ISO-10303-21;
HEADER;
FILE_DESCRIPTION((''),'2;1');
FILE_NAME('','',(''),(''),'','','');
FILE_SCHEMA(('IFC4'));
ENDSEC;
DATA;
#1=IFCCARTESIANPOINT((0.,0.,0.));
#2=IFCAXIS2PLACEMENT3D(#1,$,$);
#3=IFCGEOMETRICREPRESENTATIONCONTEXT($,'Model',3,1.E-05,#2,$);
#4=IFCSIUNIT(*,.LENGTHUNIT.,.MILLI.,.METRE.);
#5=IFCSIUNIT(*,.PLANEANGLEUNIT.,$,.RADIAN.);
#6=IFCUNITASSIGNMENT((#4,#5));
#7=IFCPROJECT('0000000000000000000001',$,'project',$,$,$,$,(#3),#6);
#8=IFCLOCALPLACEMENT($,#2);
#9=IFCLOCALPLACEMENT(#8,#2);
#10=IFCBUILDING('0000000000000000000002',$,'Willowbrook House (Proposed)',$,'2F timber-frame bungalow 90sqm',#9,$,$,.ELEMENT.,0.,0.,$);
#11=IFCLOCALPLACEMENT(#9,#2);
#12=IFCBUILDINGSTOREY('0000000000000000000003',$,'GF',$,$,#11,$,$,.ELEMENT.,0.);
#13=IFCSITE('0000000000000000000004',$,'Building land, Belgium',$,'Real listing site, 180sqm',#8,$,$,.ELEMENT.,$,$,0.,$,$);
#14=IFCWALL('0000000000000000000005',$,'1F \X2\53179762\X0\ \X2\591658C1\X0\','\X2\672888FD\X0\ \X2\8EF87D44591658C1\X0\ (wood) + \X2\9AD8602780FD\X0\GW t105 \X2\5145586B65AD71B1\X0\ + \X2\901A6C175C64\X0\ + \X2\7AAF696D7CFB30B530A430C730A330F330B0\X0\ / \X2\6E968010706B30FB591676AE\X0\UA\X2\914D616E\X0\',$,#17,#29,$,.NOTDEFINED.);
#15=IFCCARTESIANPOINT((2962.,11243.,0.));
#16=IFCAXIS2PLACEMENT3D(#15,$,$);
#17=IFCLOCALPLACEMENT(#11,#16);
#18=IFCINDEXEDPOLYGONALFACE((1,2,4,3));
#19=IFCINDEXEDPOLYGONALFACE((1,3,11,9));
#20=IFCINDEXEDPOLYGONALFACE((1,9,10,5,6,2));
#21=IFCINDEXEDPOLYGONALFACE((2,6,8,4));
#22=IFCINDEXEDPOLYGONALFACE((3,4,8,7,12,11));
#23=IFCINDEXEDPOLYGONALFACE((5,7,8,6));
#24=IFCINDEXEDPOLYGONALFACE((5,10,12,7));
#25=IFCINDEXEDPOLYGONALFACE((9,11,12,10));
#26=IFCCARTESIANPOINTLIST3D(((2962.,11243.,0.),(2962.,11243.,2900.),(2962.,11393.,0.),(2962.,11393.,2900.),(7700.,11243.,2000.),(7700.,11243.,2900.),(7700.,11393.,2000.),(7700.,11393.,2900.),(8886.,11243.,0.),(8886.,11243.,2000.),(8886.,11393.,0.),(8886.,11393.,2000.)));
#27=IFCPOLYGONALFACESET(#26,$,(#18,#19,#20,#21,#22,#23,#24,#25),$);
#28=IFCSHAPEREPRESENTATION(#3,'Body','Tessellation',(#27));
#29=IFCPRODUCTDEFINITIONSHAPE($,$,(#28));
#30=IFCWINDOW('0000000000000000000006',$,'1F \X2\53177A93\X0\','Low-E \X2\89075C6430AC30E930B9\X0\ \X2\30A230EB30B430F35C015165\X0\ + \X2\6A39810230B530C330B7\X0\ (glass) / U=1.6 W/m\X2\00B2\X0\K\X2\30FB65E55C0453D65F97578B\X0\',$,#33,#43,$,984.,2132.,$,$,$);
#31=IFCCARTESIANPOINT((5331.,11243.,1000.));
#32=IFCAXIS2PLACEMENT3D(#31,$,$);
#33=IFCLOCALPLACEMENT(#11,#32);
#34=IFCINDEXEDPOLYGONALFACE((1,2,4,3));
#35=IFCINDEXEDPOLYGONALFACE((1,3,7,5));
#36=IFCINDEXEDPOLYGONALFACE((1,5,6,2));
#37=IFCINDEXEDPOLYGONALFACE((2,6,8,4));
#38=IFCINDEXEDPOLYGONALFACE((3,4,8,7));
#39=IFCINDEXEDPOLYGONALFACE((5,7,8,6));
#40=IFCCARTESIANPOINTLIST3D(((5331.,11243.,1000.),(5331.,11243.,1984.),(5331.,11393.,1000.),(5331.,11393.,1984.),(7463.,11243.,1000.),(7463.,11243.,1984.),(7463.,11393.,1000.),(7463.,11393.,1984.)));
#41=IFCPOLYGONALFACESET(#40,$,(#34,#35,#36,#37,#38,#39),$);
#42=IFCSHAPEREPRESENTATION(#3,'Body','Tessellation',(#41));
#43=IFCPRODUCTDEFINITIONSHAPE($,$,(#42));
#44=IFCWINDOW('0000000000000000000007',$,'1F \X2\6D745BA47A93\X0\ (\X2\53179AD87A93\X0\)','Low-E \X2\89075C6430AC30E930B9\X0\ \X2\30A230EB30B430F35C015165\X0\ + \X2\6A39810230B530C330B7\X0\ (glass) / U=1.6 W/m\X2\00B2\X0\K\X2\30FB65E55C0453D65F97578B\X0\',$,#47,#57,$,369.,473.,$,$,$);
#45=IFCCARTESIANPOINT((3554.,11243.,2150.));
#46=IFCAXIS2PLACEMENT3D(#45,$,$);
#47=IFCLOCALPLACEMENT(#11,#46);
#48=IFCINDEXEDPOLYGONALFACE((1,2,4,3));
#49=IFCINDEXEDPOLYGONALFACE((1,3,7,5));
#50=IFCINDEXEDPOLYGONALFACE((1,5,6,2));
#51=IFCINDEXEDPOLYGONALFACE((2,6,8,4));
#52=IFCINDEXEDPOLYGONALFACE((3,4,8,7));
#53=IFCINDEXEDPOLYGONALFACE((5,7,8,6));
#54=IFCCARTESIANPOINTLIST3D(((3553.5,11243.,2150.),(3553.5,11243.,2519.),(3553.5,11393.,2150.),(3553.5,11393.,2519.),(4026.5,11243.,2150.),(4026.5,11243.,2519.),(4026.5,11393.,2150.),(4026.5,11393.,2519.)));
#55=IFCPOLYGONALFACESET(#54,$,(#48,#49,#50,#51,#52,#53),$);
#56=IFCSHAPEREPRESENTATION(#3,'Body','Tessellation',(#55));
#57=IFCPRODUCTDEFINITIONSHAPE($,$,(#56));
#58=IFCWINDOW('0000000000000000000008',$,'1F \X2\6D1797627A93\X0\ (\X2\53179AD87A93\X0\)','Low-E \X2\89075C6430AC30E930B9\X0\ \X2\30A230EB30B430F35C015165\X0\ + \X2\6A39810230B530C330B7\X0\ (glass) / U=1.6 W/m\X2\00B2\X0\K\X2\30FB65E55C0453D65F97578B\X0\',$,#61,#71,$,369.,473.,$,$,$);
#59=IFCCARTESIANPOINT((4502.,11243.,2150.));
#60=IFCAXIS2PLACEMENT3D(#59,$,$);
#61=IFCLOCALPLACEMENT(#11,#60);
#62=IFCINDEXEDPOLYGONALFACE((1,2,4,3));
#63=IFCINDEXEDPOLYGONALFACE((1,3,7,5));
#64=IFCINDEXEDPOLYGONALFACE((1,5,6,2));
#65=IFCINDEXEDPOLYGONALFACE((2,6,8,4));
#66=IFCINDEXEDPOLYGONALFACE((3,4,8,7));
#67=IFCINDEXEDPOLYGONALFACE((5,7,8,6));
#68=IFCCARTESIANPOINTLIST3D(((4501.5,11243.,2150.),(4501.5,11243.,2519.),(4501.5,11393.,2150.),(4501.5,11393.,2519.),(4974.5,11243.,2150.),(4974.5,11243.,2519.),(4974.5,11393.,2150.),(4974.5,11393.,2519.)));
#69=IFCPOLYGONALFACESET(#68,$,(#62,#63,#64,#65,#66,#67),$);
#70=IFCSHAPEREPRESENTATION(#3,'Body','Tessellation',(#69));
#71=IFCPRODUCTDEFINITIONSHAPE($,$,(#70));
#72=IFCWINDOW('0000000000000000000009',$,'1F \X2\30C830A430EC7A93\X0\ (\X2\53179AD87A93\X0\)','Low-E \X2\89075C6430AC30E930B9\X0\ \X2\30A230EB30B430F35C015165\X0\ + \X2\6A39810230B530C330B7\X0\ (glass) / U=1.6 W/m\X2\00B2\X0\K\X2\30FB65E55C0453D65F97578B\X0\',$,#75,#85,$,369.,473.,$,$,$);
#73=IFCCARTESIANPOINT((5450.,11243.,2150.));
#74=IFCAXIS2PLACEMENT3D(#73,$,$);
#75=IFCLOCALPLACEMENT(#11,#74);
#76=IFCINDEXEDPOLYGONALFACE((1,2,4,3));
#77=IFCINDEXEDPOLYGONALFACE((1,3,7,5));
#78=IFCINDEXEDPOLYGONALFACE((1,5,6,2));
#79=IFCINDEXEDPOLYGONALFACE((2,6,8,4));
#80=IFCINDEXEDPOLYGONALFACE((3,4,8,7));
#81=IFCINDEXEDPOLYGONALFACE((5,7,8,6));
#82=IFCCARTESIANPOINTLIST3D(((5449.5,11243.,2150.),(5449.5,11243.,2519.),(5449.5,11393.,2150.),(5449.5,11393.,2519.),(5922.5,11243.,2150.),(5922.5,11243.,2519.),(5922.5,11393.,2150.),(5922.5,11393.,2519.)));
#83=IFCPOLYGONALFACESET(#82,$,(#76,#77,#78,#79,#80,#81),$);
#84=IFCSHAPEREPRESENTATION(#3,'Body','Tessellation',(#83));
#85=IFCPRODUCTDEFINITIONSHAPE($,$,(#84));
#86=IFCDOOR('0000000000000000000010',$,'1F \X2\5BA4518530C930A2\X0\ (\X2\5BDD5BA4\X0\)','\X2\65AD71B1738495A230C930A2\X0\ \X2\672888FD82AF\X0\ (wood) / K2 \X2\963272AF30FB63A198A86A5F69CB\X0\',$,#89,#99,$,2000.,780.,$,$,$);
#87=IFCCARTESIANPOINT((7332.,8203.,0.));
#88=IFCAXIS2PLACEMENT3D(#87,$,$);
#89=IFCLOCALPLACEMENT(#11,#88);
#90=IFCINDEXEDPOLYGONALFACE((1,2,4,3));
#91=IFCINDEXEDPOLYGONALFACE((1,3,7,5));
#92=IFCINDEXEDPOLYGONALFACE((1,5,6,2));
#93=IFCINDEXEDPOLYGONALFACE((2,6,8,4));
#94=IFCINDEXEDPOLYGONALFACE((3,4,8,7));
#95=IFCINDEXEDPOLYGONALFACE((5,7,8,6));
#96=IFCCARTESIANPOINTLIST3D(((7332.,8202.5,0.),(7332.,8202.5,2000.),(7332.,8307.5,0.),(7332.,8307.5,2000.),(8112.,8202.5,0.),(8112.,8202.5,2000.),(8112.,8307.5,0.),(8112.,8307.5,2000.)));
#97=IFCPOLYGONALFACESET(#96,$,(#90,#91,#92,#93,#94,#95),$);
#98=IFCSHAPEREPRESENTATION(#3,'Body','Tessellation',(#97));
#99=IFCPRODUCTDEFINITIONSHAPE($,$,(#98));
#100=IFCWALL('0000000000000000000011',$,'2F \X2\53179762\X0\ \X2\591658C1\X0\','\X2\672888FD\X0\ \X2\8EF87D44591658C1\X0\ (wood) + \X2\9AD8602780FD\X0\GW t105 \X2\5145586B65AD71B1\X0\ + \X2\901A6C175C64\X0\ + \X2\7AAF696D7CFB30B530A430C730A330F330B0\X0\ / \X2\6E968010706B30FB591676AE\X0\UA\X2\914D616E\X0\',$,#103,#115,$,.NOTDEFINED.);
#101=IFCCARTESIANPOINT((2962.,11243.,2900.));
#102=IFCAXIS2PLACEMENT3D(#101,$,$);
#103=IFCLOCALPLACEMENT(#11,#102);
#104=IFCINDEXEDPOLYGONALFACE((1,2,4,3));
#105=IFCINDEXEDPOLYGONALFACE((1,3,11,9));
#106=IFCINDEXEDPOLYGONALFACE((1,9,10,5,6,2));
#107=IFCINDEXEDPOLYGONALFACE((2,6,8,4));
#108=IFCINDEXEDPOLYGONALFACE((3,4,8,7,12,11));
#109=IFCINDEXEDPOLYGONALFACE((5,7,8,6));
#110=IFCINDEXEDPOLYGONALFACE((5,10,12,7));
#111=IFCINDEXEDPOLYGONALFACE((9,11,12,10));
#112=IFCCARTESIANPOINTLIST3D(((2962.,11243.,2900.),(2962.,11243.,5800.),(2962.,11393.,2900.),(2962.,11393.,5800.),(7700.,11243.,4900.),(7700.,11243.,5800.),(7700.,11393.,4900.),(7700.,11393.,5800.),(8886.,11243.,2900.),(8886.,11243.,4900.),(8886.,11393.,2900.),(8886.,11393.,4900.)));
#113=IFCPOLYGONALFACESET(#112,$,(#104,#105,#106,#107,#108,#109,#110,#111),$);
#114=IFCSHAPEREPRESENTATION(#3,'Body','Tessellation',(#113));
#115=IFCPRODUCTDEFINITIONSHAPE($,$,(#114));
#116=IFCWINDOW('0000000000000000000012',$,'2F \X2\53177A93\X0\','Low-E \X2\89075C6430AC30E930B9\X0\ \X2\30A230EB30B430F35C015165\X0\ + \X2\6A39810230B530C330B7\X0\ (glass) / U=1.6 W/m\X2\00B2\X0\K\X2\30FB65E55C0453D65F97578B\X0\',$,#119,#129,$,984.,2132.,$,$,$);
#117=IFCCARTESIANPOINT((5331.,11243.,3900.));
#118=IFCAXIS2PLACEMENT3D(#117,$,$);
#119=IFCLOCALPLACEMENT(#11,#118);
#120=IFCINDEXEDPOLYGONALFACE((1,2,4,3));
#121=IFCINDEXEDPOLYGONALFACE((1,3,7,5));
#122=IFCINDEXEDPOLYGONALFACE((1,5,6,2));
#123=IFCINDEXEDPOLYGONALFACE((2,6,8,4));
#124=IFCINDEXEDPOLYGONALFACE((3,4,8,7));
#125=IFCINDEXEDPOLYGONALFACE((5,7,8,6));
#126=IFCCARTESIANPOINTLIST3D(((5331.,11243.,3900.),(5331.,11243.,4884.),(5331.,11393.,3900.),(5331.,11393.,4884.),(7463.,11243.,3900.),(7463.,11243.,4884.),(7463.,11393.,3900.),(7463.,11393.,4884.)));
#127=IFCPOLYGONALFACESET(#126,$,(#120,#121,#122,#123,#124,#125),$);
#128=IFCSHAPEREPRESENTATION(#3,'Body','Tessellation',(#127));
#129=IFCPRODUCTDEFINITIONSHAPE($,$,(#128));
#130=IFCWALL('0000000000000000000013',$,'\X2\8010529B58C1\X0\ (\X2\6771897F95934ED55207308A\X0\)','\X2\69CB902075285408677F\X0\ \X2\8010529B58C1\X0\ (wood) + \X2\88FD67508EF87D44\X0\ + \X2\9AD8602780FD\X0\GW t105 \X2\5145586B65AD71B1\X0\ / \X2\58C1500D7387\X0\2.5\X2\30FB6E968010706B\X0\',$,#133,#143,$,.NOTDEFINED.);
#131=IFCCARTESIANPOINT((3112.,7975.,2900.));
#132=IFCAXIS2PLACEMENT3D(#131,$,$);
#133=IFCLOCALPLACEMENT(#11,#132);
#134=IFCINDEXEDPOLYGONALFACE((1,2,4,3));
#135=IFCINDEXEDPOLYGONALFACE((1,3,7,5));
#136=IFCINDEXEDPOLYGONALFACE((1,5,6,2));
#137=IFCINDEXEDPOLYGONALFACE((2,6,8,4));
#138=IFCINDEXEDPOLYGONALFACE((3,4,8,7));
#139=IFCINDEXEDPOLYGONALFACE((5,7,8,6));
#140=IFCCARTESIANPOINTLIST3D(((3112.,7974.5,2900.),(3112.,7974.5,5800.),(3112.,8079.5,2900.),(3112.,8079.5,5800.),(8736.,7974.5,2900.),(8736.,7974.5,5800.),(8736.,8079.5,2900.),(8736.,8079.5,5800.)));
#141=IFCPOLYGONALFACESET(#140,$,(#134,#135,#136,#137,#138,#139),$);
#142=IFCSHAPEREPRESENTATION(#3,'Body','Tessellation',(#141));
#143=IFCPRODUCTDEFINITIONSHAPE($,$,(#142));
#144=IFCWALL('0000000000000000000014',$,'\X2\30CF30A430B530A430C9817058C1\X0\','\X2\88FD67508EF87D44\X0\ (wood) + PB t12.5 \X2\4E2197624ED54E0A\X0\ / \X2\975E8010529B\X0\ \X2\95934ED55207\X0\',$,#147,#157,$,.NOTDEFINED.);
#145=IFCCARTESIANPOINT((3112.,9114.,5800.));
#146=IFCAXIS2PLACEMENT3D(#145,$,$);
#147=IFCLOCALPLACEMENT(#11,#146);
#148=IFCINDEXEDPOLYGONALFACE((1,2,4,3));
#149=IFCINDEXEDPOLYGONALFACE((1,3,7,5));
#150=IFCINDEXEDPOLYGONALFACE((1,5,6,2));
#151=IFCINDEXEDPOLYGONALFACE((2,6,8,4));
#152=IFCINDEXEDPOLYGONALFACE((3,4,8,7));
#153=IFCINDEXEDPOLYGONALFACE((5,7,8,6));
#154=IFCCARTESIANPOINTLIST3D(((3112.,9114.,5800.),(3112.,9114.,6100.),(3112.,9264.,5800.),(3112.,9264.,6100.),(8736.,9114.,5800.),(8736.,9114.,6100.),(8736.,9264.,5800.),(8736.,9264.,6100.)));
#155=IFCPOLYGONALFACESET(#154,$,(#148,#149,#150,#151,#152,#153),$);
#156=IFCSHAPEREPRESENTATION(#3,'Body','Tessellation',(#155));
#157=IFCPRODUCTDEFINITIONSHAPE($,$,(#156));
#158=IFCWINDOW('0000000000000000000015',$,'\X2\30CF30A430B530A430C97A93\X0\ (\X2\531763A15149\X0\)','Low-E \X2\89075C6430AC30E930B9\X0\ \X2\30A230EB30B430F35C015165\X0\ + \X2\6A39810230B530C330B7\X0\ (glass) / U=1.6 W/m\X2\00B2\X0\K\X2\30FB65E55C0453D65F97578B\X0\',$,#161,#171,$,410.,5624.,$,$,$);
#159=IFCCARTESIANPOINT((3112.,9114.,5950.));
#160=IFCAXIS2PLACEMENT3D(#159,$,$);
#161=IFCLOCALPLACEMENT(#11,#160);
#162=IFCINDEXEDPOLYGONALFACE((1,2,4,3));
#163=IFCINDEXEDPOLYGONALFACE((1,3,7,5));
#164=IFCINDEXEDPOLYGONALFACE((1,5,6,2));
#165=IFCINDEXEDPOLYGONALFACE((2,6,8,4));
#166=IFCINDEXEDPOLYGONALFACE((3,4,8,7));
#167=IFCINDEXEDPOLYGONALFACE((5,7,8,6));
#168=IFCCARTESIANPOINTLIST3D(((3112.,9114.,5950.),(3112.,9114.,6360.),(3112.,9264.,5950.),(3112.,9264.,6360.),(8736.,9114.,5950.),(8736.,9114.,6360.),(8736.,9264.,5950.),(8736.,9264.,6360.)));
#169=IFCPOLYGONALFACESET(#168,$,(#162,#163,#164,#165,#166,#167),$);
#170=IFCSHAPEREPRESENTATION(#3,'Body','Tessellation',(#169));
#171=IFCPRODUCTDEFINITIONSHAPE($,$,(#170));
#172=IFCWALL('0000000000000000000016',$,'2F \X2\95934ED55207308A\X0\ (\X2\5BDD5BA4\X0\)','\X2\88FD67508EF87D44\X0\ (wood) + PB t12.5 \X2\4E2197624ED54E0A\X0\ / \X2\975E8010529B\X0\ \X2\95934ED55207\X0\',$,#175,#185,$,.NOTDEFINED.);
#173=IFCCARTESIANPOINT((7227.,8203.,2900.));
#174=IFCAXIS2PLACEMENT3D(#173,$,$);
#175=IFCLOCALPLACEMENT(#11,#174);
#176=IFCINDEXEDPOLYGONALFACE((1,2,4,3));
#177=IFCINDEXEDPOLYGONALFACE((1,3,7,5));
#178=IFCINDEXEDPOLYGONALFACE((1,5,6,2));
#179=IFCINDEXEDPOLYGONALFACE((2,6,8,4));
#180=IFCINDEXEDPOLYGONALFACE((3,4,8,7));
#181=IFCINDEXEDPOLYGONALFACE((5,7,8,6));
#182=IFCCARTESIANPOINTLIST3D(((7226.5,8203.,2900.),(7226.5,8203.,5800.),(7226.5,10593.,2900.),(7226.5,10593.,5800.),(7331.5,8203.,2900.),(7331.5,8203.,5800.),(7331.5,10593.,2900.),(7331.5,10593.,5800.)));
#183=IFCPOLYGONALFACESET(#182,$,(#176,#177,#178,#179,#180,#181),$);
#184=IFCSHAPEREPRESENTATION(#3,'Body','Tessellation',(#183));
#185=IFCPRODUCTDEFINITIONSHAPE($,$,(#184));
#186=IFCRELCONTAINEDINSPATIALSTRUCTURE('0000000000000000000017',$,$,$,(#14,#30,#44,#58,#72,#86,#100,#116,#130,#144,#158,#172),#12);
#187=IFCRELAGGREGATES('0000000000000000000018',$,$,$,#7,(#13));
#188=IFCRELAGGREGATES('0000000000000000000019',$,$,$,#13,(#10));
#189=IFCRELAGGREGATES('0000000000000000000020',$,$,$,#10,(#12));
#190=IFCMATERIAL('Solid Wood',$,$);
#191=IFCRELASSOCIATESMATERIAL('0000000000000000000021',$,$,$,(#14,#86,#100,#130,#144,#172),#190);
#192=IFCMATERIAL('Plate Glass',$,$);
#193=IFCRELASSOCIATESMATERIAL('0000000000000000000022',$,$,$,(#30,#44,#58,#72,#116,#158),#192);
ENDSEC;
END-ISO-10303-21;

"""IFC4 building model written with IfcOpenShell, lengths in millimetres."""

from ifc_helpers import new_model, si_unit, frame, frame_2d, origin, place, context, project, spatial, rectangle, extrude, material, element, fill, save


model = new_model("IFC4")

# Units and contexts
model_context = context("Model", 3, precision=1e-05, world=origin())
ifc_project = project(units=[si_unit("LENGTHUNIT", "METRE", prefix="MILLI"), si_unit("PLANEANGLEUNIT", "RADIAN")], contexts=[model_context])

# Site, building, storey
site_placement = place(None, origin())
site = spatial("IfcSite", under=ifc_project, at=site_placement, Name="Building land, Belgium", ObjectType="Real listing site, 180sqm", CompositionType="ELEMENT", RefElevation=0.0)
building_placement = place(site_placement, origin())
building = spatial("IfcBuilding", under=site, at=building_placement, Name="Willowbrook House (Proposed)", ObjectType="2F timber-frame bungalow 90sqm", CompositionType="ELEMENT", ElevationOfRefHeight=0.0, ElevationOfTerrain=0.0)
storey_placement = place(building_placement, origin())
storey = spatial("IfcBuildingStorey", under=building, at=storey_placement, Name="GF", CompositionType="ELEMENT", Elevation=0.0)

# Wall, openings, windows
ifc_material_1 = material(Name="Solid Wood")
wall_1_placement = place(storey_placement, frame((2962.0, 11243.0, 0.0)))
wall_1 = element("IfcWall", 1, at=wall_1_placement, inside=storey, material=ifc_material_1, Name="1F 北面 外壁", Description="木製 軸組外壁 (wood) + 高性能GW t105 充填断熱 + 通気層 + 窯業系サイディング / 準耐火・外皮UA配慮", PredefinedType="NOTDEFINED", context=model_context, shape_type="SweptSolid", body=[
    extrude(rectangle(XDim=5924.0, YDim=150.0, at=frame_2d((2962.0, 75.0))), frame((2962.0, 11243.0, 0.0)), (0.0, 0.0, 1.0), 2900.0),
])
opening_1_placement = place(storey_placement, frame((5331.0, 11243.0, 1000.0)))
opening_1 = element("IfcOpeningElement", 2, at=opening_1_placement, cuts=wall_1, PredefinedType="NOTDEFINED", context=model_context, shape_type="SweptSolid", body=[
    extrude(rectangle(XDim=2132.0, YDim=150.0, at=frame_2d((1066.0, 75.0))), frame((5331.0, 11243.0, 1000.0)), (0.0, 0.0, 1.0), 984.0),
])
opening_2_placement = place(storey_placement, frame((3554.0, 11243.0, 2150.0)))
opening_2 = element("IfcOpeningElement", 3, at=opening_2_placement, cuts=wall_1, PredefinedType="NOTDEFINED", context=model_context, shape_type="SweptSolid", body=[
    extrude(rectangle(XDim=473.0, YDim=150.0, at=frame_2d((236.0, 75.0))), frame((3554.0, 11243.0, 2150.0)), (0.0, 0.0, 1.0), 369.0),
])
opening_3_placement = place(storey_placement, frame((4502.0, 11243.0, 2150.0)))
opening_3 = element("IfcOpeningElement", 4, at=opening_3_placement, cuts=wall_1, PredefinedType="NOTDEFINED", context=model_context, shape_type="SweptSolid", body=[
    extrude(rectangle(XDim=473.0, YDim=150.0, at=frame_2d((236.0, 75.0))), frame((4502.0, 11243.0, 2150.0)), (0.0, 0.0, 1.0), 369.0),
])
opening_4_placement = place(storey_placement, frame((5450.0, 11243.0, 2150.0)))
opening_4 = element("IfcOpeningElement", 5, at=opening_4_placement, cuts=wall_1, PredefinedType="NOTDEFINED", context=model_context, shape_type="SweptSolid", body=[
    extrude(rectangle(XDim=473.0, YDim=150.0, at=frame_2d((236.0, 75.0))), frame((5450.0, 11243.0, 2150.0)), (0.0, 0.0, 1.0), 369.0),
])
ifc_material_2 = material(Name="Plate Glass")
window_1_placement = place(storey_placement, frame((5331.0, 11243.0, 1000.0)))
window_1 = element("IfcWindow", 6, at=window_1_placement, inside=storey, material=ifc_material_2, Name="1F 北窓", Description="Low-E 複層ガラス アルゴン封入 + 樹脂サッシ (glass) / U=1.6 W/m²K・日射取得型", OverallHeight=984.0, OverallWidth=2132.0, context=model_context, shape_type="SweptSolid", body=[
    extrude(rectangle(XDim=2132.0, YDim=150.0, at=frame_2d((1066.0, 75.0))), frame((5331.0, 11243.0, 1000.0)), (0.0, 0.0, 1.0), 984.0),
])
fill(opening_1, window_1)
window_2_placement = place(storey_placement, frame((3554.0, 11243.0, 2150.0)))
window_2 = element("IfcWindow", 7, at=window_2_placement, inside=storey, material=ifc_material_2, Name="1F 浴室窓 (北高窓)", Description="Low-E 複層ガラス アルゴン封入 + 樹脂サッシ (glass) / U=1.6 W/m²K・日射取得型", OverallHeight=369.0, OverallWidth=473.0, context=model_context, shape_type="SweptSolid", body=[
    extrude(rectangle(XDim=473.0, YDim=150.0, at=frame_2d((236.0, 75.0))), frame((3554.0, 11243.0, 2150.0)), (0.0, 0.0, 1.0), 369.0),
])
fill(opening_2, window_2)
window_3_placement = place(storey_placement, frame((4502.0, 11243.0, 2150.0)))
window_3 = element("IfcWindow", 8, at=window_3_placement, inside=storey, material=ifc_material_2, Name="1F 洗面窓 (北高窓)", Description="Low-E 複層ガラス アルゴン封入 + 樹脂サッシ (glass) / U=1.6 W/m²K・日射取得型", OverallHeight=369.0, OverallWidth=473.0, context=model_context, shape_type="SweptSolid", body=[
    extrude(rectangle(XDim=473.0, YDim=150.0, at=frame_2d((236.0, 75.0))), frame((4502.0, 11243.0, 2150.0)), (0.0, 0.0, 1.0), 369.0),
])
fill(opening_3, window_3)
window_4_placement = place(storey_placement, frame((5450.0, 11243.0, 2150.0)))
window_4 = element("IfcWindow", 9, at=window_4_placement, inside=storey, material=ifc_material_2, Name="1F トイレ窓 (北高窓)", Description="Low-E 複層ガラス アルゴン封入 + 樹脂サッシ (glass) / U=1.6 W/m²K・日射取得型", OverallHeight=369.0, OverallWidth=473.0, context=model_context, shape_type="SweptSolid", body=[
    extrude(rectangle(XDim=473.0, YDim=150.0, at=frame_2d((236.0, 75.0))), frame((5450.0, 11243.0, 2150.0)), (0.0, 0.0, 1.0), 369.0),
])
fill(opening_4, window_4)

# Door
door_1_placement = place(storey_placement, frame((7332.0, 8203.0, 0.0)))
element("IfcDoor", 10, at=door_1_placement, inside=storey, material=ifc_material_1, Name="1F 室内ドア (寝室)", Description="断熱玄関ドア 木製芯 (wood) / K2 防犯・採風機構", OverallHeight=2000.0, OverallWidth=780.0, context=model_context, shape_type="SweptSolid", body=[
    extrude(rectangle(XDim=780.0, YDim=105.0, at=frame_2d((390.0, 52.0))), frame((7332.0, 8203.0, 0.0)), (0.0, 0.0, 1.0), 2000.0),
])

# Wall, opening, window
wall_2_placement = place(storey_placement, frame((2962.0, 11243.0, 2900.0)))
wall_2 = element("IfcWall", 11, at=wall_2_placement, inside=storey, material=ifc_material_1, Name="2F 北面 外壁", Description="木製 軸組外壁 (wood) + 高性能GW t105 充填断熱 + 通気層 + 窯業系サイディング / 準耐火・外皮UA配慮", PredefinedType="NOTDEFINED", context=model_context, shape_type="SweptSolid", body=[
    extrude(rectangle(XDim=5924.0, YDim=150.0, at=frame_2d((2962.0, 75.0))), frame((2962.0, 11243.0, 2900.0)), (0.0, 0.0, 1.0), 2900.0),
])
opening_5_placement = place(storey_placement, frame((5331.0, 11243.0, 3900.0)))
opening_5 = element("IfcOpeningElement", 12, at=opening_5_placement, cuts=wall_2, PredefinedType="NOTDEFINED", context=model_context, shape_type="SweptSolid", body=[
    extrude(rectangle(XDim=2132.0, YDim=150.0, at=frame_2d((1066.0, 75.0))), frame((5331.0, 11243.0, 3900.0)), (0.0, 0.0, 1.0), 984.0),
])
window_5_placement = place(storey_placement, frame((5331.0, 11243.0, 3900.0)))
window_5 = element("IfcWindow", 13, at=window_5_placement, inside=storey, material=ifc_material_2, Name="2F 北窓", Description="Low-E 複層ガラス アルゴン封入 + 樹脂サッシ (glass) / U=1.6 W/m²K・日射取得型", OverallHeight=984.0, OverallWidth=2132.0, context=model_context, shape_type="SweptSolid", body=[
    extrude(rectangle(XDim=2132.0, YDim=150.0, at=frame_2d((1066.0, 75.0))), frame((5331.0, 11243.0, 3900.0)), (0.0, 0.0, 1.0), 984.0),
])
fill(opening_5, window_5)

# Wall
wall_3_placement = place(storey_placement, frame((3112.0, 7975.0, 2900.0)))
element("IfcWall", 14, at=wall_3_placement, inside=storey, material=ifc_material_1, Name="耐力壁 (東西間仕切り)", Description="構造用合板 耐力壁 (wood) + 製材軸組 + 高性能GW t105 充填断熱 / 壁倍率2.5・準耐火", PredefinedType="NOTDEFINED", context=model_context, shape_type="SweptSolid", body=[
    extrude(rectangle(XDim=5624.0, YDim=105.0, at=frame_2d((2812.0, 52.0))), frame((3112.0, 7975.0, 2900.0)), (0.0, 0.0, 1.0), 2900.0),
])

# Wall, opening, window
wall_4_placement = place(storey_placement, frame((3112.0, 9114.0, 5800.0)))
wall_4 = element("IfcWall", 15, at=wall_4_placement, inside=storey, material=ifc_material_1, Name="ハイサイド腰壁", Description="製材軸組 (wood) + PB t12.5 両面仕上 / 非耐力 間仕切", PredefinedType="NOTDEFINED", context=model_context, shape_type="SweptSolid", body=[
    extrude(rectangle(XDim=5624.0, YDim=150.0, at=frame_2d((2812.0, 75.0))), frame((3112.0, 9114.0, 5800.0)), (0.0, 0.0, 1.0), 700.0),
])
opening_6_placement = place(storey_placement, frame((3112.0, 9114.0, 5950.0)))
opening_6 = element("IfcOpeningElement", 16, at=opening_6_placement, cuts=wall_4, PredefinedType="NOTDEFINED", context=model_context, shape_type="SweptSolid", body=[
    extrude(rectangle(XDim=5624.0, YDim=150.0, at=frame_2d((2812.0, 75.0))), frame((3112.0, 9114.0, 5950.0)), (0.0, 0.0, 1.0), 410.0),
])
window_6_placement = place(storey_placement, frame((3112.0, 9114.0, 5950.0)))
window_6 = element("IfcWindow", 17, at=window_6_placement, inside=storey, material=ifc_material_2, Name="ハイサイド窓 (北採光)", Description="Low-E 複層ガラス アルゴン封入 + 樹脂サッシ (glass) / U=1.6 W/m²K・日射取得型", OverallHeight=410.0, OverallWidth=5624.0, context=model_context, shape_type="SweptSolid", body=[
    extrude(rectangle(XDim=5624.0, YDim=150.0, at=frame_2d((2812.0, 75.0))), frame((3112.0, 9114.0, 5950.0)), (0.0, 0.0, 1.0), 410.0),
])
fill(opening_6, window_6)

# Wall
wall_5_placement = place(storey_placement, frame((7227.0, 8203.0, 2900.0)))
element("IfcWall", 18, at=wall_5_placement, inside=storey, material=ifc_material_1, Name="2F 間仕切り (寝室)", Description="製材軸組 (wood) + PB t12.5 両面仕上 / 非耐力 間仕切", PredefinedType="NOTDEFINED", context=model_context, shape_type="SweptSolid", body=[
    extrude(rectangle(XDim=105.0, YDim=2390.0, at=frame_2d((52.0, 1195.0))), frame((7227.0, 8203.0, 2900.0)), (0.0, 0.0, 1.0), 2900.0),
])

save(model, "model.ifc")
